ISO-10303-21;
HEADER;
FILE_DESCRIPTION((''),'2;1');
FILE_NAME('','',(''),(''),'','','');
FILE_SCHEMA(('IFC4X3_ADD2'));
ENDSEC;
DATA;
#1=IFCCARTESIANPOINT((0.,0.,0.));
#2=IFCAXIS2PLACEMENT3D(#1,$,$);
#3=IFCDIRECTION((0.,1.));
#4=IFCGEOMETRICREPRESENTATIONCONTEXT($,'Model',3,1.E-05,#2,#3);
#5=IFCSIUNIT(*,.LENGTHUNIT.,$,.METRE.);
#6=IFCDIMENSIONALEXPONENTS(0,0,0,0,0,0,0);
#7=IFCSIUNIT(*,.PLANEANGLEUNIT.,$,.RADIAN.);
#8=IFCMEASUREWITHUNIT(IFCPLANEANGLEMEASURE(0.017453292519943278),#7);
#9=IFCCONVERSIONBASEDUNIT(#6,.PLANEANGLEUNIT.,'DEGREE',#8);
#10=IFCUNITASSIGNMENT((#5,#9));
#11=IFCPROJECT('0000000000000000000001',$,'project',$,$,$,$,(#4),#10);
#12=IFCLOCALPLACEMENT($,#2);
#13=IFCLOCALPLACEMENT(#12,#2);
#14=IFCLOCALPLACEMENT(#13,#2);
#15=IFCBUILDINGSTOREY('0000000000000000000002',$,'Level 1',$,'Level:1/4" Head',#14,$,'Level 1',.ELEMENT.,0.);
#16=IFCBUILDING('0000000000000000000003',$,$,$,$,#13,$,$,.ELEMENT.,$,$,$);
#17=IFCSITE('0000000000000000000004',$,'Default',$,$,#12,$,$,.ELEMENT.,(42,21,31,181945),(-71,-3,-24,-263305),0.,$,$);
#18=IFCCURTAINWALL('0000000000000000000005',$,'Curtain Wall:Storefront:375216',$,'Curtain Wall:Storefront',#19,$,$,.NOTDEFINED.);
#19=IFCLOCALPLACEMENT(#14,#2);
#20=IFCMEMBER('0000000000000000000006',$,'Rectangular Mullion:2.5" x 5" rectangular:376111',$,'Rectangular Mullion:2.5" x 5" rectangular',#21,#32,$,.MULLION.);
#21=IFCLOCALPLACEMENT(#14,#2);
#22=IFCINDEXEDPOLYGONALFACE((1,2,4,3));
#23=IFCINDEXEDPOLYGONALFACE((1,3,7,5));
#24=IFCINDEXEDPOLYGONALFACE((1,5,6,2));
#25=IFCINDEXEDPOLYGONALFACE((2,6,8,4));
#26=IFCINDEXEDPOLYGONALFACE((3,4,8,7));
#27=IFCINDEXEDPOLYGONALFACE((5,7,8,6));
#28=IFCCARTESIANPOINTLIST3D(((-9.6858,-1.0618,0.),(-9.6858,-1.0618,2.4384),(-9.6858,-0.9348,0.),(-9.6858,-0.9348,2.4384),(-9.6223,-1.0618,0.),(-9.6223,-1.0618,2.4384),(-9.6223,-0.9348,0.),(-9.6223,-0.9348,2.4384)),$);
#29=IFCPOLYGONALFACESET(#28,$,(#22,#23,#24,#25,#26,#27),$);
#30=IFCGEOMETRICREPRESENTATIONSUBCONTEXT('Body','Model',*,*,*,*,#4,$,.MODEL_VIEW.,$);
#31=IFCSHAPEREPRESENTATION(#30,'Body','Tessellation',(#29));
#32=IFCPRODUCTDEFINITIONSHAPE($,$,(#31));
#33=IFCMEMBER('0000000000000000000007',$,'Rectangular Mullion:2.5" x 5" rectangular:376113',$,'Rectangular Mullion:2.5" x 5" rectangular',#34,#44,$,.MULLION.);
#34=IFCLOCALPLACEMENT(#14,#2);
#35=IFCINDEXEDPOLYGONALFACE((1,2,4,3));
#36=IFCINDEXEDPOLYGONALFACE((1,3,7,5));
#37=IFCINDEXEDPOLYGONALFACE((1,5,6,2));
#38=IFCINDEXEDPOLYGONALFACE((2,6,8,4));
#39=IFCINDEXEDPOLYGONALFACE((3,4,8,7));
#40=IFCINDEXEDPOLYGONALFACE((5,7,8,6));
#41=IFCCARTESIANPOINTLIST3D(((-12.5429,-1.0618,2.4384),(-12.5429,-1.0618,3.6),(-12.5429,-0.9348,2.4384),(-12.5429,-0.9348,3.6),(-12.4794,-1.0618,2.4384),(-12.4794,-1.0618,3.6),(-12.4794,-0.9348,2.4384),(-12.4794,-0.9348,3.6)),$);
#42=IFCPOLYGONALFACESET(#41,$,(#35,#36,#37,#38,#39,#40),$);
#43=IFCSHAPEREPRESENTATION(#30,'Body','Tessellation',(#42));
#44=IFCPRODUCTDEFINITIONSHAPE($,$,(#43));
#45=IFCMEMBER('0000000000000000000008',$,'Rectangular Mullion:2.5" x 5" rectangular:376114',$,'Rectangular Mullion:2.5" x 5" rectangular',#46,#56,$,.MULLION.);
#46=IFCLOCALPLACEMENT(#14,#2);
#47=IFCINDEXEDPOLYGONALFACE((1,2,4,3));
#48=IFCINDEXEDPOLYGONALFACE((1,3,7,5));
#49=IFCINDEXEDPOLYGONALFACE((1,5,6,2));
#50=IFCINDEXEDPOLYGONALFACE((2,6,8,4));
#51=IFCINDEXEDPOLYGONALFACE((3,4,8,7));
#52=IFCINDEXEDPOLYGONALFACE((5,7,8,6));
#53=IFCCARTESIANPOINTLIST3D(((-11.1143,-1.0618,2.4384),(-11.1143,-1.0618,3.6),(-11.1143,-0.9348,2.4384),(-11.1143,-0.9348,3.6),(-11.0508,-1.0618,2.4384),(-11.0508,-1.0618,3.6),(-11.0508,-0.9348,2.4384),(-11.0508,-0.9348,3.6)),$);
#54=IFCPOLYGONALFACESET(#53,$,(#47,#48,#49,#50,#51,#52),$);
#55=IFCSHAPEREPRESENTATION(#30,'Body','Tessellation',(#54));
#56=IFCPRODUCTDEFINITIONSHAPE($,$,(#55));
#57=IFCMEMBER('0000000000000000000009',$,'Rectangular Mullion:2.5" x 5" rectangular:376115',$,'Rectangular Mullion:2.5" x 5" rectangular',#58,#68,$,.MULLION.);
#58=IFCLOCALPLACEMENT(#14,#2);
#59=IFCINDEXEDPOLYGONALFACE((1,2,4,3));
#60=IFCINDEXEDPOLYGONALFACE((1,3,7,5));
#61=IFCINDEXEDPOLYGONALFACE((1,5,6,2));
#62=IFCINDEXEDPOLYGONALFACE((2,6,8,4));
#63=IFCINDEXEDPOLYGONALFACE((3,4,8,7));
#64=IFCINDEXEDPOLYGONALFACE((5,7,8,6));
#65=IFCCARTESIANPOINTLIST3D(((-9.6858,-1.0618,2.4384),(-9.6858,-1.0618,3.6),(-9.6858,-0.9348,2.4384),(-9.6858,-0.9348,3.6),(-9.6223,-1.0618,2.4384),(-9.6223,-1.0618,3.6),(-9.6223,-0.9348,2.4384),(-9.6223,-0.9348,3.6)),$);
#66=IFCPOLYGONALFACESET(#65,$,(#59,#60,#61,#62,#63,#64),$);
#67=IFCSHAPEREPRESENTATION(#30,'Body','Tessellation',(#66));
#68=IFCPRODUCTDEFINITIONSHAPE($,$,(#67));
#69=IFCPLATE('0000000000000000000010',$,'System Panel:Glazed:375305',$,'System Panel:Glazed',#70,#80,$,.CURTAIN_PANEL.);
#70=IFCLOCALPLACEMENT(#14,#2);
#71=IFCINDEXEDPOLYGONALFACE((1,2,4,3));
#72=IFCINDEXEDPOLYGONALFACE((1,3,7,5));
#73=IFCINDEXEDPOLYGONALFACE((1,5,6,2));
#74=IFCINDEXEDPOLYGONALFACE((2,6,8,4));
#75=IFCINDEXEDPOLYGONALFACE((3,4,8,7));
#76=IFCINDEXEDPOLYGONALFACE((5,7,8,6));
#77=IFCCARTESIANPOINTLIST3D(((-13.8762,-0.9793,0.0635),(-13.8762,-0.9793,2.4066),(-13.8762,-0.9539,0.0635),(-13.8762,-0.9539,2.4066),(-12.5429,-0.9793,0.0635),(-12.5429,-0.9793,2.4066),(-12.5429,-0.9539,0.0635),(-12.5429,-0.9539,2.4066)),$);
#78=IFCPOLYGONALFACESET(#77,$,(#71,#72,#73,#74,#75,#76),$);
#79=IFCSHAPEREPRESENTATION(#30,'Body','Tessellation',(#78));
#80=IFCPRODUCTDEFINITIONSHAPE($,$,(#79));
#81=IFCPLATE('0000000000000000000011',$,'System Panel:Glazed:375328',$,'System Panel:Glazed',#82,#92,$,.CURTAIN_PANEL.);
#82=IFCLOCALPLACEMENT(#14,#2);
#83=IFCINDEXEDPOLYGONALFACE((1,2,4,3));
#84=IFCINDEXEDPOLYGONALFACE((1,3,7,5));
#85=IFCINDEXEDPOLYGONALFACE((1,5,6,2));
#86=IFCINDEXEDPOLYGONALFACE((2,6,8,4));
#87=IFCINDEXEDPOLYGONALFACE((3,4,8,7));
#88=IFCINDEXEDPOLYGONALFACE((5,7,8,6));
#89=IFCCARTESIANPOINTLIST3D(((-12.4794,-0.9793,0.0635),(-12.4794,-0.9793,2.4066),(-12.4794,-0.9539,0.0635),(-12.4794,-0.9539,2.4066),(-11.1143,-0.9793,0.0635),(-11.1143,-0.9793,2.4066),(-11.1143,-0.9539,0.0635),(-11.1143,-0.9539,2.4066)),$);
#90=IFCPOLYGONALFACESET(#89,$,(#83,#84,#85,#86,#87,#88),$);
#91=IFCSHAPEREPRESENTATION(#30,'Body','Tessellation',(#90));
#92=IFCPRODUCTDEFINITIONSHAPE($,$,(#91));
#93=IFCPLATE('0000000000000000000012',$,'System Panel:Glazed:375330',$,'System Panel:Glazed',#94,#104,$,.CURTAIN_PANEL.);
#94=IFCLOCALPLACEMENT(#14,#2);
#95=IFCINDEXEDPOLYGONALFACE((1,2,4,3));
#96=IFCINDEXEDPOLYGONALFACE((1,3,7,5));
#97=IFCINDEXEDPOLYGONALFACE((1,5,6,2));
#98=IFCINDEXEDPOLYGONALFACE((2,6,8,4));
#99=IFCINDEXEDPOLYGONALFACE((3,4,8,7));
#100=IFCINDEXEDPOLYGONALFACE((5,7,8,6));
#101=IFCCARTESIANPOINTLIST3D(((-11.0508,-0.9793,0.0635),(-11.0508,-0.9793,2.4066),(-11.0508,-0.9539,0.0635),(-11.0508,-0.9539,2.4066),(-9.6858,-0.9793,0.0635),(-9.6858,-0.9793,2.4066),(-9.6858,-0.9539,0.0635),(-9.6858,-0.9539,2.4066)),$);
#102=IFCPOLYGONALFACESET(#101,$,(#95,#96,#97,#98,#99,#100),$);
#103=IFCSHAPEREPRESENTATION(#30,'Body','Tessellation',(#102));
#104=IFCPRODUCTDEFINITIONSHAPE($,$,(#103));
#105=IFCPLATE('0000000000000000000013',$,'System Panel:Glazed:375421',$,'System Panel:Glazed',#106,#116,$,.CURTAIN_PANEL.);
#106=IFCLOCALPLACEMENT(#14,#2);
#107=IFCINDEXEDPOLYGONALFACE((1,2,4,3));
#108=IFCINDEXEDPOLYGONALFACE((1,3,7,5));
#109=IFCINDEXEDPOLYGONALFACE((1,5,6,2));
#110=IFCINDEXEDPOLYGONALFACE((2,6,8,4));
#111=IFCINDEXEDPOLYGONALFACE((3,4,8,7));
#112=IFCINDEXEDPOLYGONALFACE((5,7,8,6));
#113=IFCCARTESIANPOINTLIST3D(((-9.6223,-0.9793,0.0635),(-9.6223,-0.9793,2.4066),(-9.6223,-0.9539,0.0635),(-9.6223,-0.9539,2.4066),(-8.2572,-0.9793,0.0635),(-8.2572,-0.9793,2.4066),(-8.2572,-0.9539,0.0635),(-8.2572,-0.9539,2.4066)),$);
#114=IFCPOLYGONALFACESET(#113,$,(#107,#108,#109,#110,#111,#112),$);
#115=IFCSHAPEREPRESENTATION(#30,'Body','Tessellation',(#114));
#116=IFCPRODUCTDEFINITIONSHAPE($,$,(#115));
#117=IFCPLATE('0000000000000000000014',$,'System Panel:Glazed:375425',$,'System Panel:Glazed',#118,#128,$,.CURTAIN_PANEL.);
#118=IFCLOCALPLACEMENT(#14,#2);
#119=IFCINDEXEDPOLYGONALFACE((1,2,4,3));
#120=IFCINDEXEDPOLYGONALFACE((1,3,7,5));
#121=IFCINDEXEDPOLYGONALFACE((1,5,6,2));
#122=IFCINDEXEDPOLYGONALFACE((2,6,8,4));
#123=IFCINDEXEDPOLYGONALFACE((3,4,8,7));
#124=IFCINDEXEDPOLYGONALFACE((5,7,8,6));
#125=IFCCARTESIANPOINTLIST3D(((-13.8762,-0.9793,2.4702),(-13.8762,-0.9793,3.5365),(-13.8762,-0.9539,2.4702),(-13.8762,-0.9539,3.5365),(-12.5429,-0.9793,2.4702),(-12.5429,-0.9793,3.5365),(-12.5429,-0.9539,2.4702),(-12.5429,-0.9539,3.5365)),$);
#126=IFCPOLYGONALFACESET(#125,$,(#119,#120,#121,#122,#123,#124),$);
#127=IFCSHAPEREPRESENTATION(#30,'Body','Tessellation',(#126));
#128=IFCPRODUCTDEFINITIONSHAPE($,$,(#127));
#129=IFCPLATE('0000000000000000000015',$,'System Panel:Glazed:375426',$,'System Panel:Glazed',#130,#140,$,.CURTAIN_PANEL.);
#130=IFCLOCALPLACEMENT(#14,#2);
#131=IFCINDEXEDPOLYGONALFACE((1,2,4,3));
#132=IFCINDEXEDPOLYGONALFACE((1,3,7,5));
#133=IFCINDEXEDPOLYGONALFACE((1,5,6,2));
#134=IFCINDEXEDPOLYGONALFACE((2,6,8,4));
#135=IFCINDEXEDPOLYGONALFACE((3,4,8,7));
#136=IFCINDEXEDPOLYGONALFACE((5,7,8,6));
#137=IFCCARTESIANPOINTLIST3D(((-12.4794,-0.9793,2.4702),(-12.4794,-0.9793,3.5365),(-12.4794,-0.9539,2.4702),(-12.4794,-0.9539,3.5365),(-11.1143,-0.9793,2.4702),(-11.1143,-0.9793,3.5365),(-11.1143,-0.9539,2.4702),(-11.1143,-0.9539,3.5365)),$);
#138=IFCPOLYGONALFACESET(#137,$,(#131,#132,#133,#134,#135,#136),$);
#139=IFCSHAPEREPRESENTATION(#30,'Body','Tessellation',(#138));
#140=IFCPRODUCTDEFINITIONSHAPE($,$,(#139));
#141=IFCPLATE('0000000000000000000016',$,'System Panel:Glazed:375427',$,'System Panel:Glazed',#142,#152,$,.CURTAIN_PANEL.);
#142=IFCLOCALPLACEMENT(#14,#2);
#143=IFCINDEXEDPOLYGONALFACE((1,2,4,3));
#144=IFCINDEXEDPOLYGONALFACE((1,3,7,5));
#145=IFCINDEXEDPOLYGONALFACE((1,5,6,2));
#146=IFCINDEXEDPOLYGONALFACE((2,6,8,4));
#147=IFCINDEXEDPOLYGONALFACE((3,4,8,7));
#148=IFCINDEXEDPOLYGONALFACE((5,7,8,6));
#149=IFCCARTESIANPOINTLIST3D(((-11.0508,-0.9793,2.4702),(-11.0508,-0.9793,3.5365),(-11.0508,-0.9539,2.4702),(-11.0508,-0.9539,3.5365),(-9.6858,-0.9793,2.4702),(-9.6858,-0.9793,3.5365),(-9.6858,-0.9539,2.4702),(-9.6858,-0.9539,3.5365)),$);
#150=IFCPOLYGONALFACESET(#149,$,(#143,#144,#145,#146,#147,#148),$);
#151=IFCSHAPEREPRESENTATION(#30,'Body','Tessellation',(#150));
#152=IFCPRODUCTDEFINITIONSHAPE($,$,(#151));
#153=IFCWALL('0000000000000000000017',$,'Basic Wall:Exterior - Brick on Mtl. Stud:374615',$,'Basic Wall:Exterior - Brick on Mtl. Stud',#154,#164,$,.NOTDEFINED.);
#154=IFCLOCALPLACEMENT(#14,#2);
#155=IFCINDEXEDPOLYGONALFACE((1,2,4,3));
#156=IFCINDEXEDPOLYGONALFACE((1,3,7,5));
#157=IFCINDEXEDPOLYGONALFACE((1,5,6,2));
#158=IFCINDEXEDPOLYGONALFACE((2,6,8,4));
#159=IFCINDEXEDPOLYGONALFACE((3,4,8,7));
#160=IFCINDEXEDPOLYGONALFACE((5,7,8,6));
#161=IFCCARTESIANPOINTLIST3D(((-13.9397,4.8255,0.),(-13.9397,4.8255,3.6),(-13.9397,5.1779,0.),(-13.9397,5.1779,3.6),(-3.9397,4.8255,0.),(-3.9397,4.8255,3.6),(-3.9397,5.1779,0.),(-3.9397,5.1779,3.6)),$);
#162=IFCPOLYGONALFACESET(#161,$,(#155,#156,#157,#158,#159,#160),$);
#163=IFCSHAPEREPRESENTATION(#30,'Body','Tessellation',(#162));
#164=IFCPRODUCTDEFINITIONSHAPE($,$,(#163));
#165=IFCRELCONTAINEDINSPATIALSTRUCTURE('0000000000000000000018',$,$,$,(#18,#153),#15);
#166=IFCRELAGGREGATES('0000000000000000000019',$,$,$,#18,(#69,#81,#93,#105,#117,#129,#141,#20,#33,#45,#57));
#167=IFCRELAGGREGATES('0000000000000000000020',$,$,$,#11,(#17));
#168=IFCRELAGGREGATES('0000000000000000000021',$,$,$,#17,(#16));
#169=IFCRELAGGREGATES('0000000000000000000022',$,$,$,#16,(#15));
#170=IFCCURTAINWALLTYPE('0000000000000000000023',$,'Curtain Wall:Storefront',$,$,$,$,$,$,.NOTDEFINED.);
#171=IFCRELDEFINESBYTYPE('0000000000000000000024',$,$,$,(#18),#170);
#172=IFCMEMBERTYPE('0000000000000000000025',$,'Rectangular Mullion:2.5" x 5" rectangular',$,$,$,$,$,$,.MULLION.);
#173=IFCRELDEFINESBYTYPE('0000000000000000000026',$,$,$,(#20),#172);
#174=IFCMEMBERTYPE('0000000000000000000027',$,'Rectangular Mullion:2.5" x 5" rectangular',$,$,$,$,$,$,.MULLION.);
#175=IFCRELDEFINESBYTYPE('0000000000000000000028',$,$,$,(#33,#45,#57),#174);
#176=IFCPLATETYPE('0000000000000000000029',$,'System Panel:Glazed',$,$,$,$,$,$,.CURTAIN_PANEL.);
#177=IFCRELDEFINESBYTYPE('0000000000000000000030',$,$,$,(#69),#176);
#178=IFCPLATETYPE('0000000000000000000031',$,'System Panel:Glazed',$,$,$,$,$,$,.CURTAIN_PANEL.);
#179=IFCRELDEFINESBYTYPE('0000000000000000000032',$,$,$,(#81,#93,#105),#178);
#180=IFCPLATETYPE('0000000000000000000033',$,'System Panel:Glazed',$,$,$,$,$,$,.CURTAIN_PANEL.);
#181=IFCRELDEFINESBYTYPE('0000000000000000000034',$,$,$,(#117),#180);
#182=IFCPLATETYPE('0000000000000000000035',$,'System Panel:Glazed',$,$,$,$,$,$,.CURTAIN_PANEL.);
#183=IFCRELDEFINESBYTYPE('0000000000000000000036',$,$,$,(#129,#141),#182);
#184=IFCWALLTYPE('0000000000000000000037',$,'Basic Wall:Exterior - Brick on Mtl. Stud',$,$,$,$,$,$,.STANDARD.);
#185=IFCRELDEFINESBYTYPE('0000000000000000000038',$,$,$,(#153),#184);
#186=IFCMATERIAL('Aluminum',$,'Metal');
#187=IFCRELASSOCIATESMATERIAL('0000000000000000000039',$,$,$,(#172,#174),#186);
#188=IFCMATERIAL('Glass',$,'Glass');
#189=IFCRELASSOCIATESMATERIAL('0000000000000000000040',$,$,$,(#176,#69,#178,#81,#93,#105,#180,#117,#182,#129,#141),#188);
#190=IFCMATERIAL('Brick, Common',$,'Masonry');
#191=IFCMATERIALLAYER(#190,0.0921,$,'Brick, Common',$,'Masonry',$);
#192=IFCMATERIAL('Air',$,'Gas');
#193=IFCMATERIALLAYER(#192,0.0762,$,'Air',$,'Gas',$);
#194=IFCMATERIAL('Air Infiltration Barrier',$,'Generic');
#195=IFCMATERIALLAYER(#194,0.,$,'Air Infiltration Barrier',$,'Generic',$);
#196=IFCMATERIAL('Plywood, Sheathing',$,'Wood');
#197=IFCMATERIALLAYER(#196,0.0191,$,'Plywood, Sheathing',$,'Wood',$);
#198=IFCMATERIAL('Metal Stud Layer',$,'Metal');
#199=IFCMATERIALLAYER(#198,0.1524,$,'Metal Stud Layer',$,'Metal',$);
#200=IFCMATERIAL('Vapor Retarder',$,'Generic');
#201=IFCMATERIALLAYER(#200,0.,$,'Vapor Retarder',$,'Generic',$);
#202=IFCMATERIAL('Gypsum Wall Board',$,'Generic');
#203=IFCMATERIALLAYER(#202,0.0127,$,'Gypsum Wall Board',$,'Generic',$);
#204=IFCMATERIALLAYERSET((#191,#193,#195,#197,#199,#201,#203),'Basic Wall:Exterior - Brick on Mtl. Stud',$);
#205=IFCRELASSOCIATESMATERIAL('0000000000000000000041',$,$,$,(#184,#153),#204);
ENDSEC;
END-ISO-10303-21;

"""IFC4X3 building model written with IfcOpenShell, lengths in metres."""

from ifc_helpers import new_model, entity, si_unit, converted_unit, direction, frame, frame_2d, origin, origin_2d_with_axis, place, context, subcontext, project, spatial, rectangle, extrude, source, transform, mapped, material, layer, layer_set, material_profile, profile_set, type_object, type_shapes, element, aggregate, save


model = new_model("IFC4X3")

# Units and contexts
model_context = context("Model", 3, precision=1e-05, world=origin(), true_north=direction((0.0, 1.0)))
body_context = subcontext(model_context, "Body", "Model", "MODEL_VIEW")
ifc_project = project(units=[si_unit("LENGTHUNIT", "METRE"), converted_unit("PLANEANGLEUNIT", "DEGREE", entity("IfcPlaneAngleMeasure", 0.017453292519943278), si_unit("PLANEANGLEUNIT", "RADIAN"), dimensions=[0, 0, 0, 0, 0, 0, 0])], contexts=[model_context])

# Site, building, storey
site_placement = place(None, origin())
site = spatial("IfcSite", under=ifc_project, at=site_placement, Name="Default", CompositionType="ELEMENT", RefLatitude=(42, 21, 31, 181945), RefLongitude=(-71, -3, -24, -263305), RefElevation=0.0)
building_placement = place(site_placement, origin())
building = spatial("IfcBuilding", under=site, at=building_placement, CompositionType="ELEMENT")
storey_placement = place(building_placement, origin())
storey = spatial("IfcBuildingStorey", under=building, at=storey_placement, Name="Level 1", ObjectType="Level:1/4\" Head", LongName="Level 1", CompositionType="ELEMENT", Elevation=0.0)

# Curtain wall, members, plates
curtain_wall_type = type_object("IfcCurtainWallType", Name="Curtain Wall:Storefront", PredefinedType="NOTDEFINED")
curtain_wall_placement = place(storey_placement, origin())
curtain_wall = element("IfcCurtainWall", 1, at=curtain_wall_placement, inside=storey, type_object=curtain_wall_type, Name="Curtain Wall:Storefront:375216", ObjectType="Curtain Wall:Storefront", PredefinedType="NOTDEFINED")
ifc_material_1 = material(Name="Aluminum", Category="Metal")
ifc_material_profile = material_profile(ifc_material_1, rectangle(XDim=0.0635, YDim=0.127, at=frame_2d((0.0, 0.0), x_axis=(1.0, 0.0))), Name="2.5\" x 5\" rectangular")
ifc_profile_set = profile_set([ifc_material_profile], Name="2.5\" x 5\" rectangular")
member_type_1 = type_object("IfcMemberType", Name="Rectangular Mullion:2.5\" x 5\" rectangular", PredefinedType="MULLION", material=ifc_profile_set)
shared_shape_1 = source(origin(), body_context, "Body", "SweptSolid", [
    extrude(rectangle(XDim=0.0635, YDim=0.127, at=origin_2d_with_axis()), frame((0.0, 0.0, -2.4384), z_axis=(0.0, 0.0, 1.0), x_axis=(-1.0, 0.0, 0.0)), (0.0, 0.0, 1.0), 2.4384),
])
type_shapes(member_type_1, [shared_shape_1])
member_1_placement = place(curtain_wall_placement, frame((-9.654, -0.9983, 0.0), z_axis=(0.0, 0.0, -1.0), x_axis=(1.0, 0.0, 0.0)))
member_1 = element("IfcMember", 2, at=member_1_placement, type_object=member_type_1, Name="Rectangular Mullion:2.5\" x 5\" rectangular:376111", ObjectType="Rectangular Mullion:2.5\" x 5\" rectangular", PredefinedType="MULLION", context=body_context, shape_type="MappedRepresentation", body=[
    mapped(shared_shape_1, transform((0.0, 0.0, 0.0), scale=1.0)),
])
member_type_2 = type_object("IfcMemberType", Name="Rectangular Mullion:2.5\" x 5\" rectangular", PredefinedType="MULLION", material=ifc_profile_set)
shared_shape_2 = source(origin(), body_context, "Body", "SweptSolid", [
    extrude(rectangle(XDim=0.0635, YDim=0.127, at=origin_2d_with_axis()), frame((0.0, 0.0, -1.1616), z_axis=(0.0, 0.0, 1.0), x_axis=(-1.0, 0.0, 0.0)), (0.0, 0.0, 1.0), 1.1616),
])
type_shapes(member_type_2, [shared_shape_2])
member_2_placement = place(curtain_wall_placement, frame((-12.5112, -0.9983, 2.4384), z_axis=(0.0, 0.0, -1.0), x_axis=(1.0, 0.0, 0.0)))
member_2 = element("IfcMember", 3, at=member_2_placement, type_object=member_type_2, Name="Rectangular Mullion:2.5\" x 5\" rectangular:376113", ObjectType="Rectangular Mullion:2.5\" x 5\" rectangular", PredefinedType="MULLION", context=body_context, shape_type="MappedRepresentation", body=[
    mapped(shared_shape_2, transform((0.0, 0.0, 0.0), scale=1.0)),
])
member_3_placement = place(curtain_wall_placement, frame((-11.0826, -0.9983, 2.4384), z_axis=(0.0, 0.0, -1.0), x_axis=(1.0, 0.0, 0.0)))
member_3 = element("IfcMember", 4, at=member_3_placement, type_object=member_type_2, Name="Rectangular Mullion:2.5\" x 5\" rectangular:376114", ObjectType="Rectangular Mullion:2.5\" x 5\" rectangular", PredefinedType="MULLION", context=body_context, shape_type="MappedRepresentation", body=[
    mapped(shared_shape_2, transform((0.0, 0.0, 0.0), scale=1.0)),
])
member_4_placement = place(curtain_wall_placement, frame((-9.654, -0.9983, 2.4384), z_axis=(0.0, 0.0, -1.0), x_axis=(1.0, 0.0, 0.0)))
member_4 = element("IfcMember", 5, at=member_4_placement, type_object=member_type_2, Name="Rectangular Mullion:2.5\" x 5\" rectangular:376115", ObjectType="Rectangular Mullion:2.5\" x 5\" rectangular", PredefinedType="MULLION", context=body_context, shape_type="MappedRepresentation", body=[
    mapped(shared_shape_2, transform((0.0, 0.0, 0.0), scale=1.0)),
])
ifc_material_2 = material(Name="Glass", Category="Glass")
plate_type_1 = type_object("IfcPlateType", Name="System Panel:Glazed", PredefinedType="CURTAIN_PANEL", material=ifc_material_2)
shared_shape_3 = source(origin(), body_context, "Body", "SweptSolid", [
    extrude(rectangle(XDim=0.0254, YDim=1.3333, at=frame_2d((0.0, 0.0), x_axis=(1.0, 0.0))), frame((0.6667, 0.0127, 0.0), z_axis=(0.0, 0.0, 1.0), x_axis=(0.0, 1.0, 0.0)), (0.0, 0.0, 1.0), 2.3432),
])
type_shapes(plate_type_1, [shared_shape_3])
plate_1_placement = place(curtain_wall_placement, frame((-13.8762, -0.9793, 0.0635)))
plate_1 = element("IfcPlate", 6, at=plate_1_placement, type_object=plate_type_1, material=ifc_material_2, Name="System Panel:Glazed:375305", ObjectType="System Panel:Glazed", PredefinedType="CURTAIN_PANEL", context=body_context, shape_type="MappedRepresentation", body=[
    mapped(shared_shape_3, transform((0.0, 0.0, 0.0), scale=1.0)),
])
plate_type_2 = type_object("IfcPlateType", Name="System Panel:Glazed", PredefinedType="CURTAIN_PANEL", material=ifc_material_2)
shared_shape_4 = source(origin(), body_context, "Body", "SweptSolid", [
    extrude(rectangle(XDim=0.0254, YDim=1.3651, at=frame_2d((0.0, 0.0), x_axis=(1.0, 0.0))), frame((0.6825, 0.0127, 0.0), z_axis=(0.0, 0.0, 1.0), x_axis=(0.0, 1.0, 0.0)), (0.0, 0.0, 1.0), 2.3432),
])
type_shapes(plate_type_2, [shared_shape_4])
plate_2_placement = place(curtain_wall_placement, frame((-12.4794, -0.9793, 0.0635)))
plate_2 = element("IfcPlate", 7, at=plate_2_placement, type_object=plate_type_2, material=ifc_material_2, Name="System Panel:Glazed:375328", ObjectType="System Panel:Glazed", PredefinedType="CURTAIN_PANEL", context=body_context, shape_type="MappedRepresentation", body=[
    mapped(shared_shape_4, transform((0.0, 0.0, 0.0), scale=1.0)),
])
plate_3_placement = place(curtain_wall_placement, frame((-11.0508, -0.9793, 0.0635)))
plate_3 = element("IfcPlate", 8, at=plate_3_placement, type_object=plate_type_2, material=ifc_material_2, Name="System Panel:Glazed:375330", ObjectType="System Panel:Glazed", PredefinedType="CURTAIN_PANEL", context=body_context, shape_type="MappedRepresentation", body=[
    mapped(shared_shape_4, transform((0.0, 0.0, 0.0), scale=1.0)),
])
plate_4_placement = place(curtain_wall_placement, frame((-9.6223, -0.9793, 0.0635)))
plate_4 = element("IfcPlate", 9, at=plate_4_placement, type_object=plate_type_2, material=ifc_material_2, Name="System Panel:Glazed:375421", ObjectType="System Panel:Glazed", PredefinedType="CURTAIN_PANEL", context=body_context, shape_type="MappedRepresentation", body=[
    mapped(shared_shape_4, transform((0.0, 0.0, 0.0), scale=1.0)),
])
plate_type_3 = type_object("IfcPlateType", Name="System Panel:Glazed", PredefinedType="CURTAIN_PANEL", material=ifc_material_2)
shared_shape_5 = source(origin(), body_context, "Body", "SweptSolid", [
    extrude(rectangle(XDim=0.0254, YDim=1.3333, at=frame_2d((0.0, 0.0), x_axis=(1.0, 0.0))), frame((0.6667, 0.0127, 0.0), z_axis=(0.0, 0.0, 1.0), x_axis=(0.0, 1.0, 0.0)), (0.0, 0.0, 1.0), 1.0663),
])
type_shapes(plate_type_3, [shared_shape_5])
plate_5_placement = place(curtain_wall_placement, frame((-13.8762, -0.9793, 2.4701)))
plate_5 = element("IfcPlate", 10, at=plate_5_placement, type_object=plate_type_3, material=ifc_material_2, Name="System Panel:Glazed:375425", ObjectType="System Panel:Glazed", PredefinedType="CURTAIN_PANEL", context=body_context, shape_type="MappedRepresentation", body=[
    mapped(shared_shape_5, transform((0.0, 0.0, 0.0), scale=1.0)),
])
plate_type_4 = type_object("IfcPlateType", Name="System Panel:Glazed", PredefinedType="CURTAIN_PANEL", material=ifc_material_2)
shared_shape_6 = source(origin(), body_context, "Body", "SweptSolid", [
    extrude(rectangle(XDim=0.0254, YDim=1.3651, at=frame_2d((0.0, 0.0), x_axis=(1.0, 0.0))), frame((0.6825, 0.0127, 0.0), z_axis=(0.0, 0.0, 1.0), x_axis=(0.0, 1.0, 0.0)), (0.0, 0.0, 1.0), 1.0663),
])
type_shapes(plate_type_4, [shared_shape_6])
plate_6_placement = place(curtain_wall_placement, frame((-12.4794, -0.9793, 2.4701)))
plate_6 = element("IfcPlate", 11, at=plate_6_placement, type_object=plate_type_4, material=ifc_material_2, Name="System Panel:Glazed:375426", ObjectType="System Panel:Glazed", PredefinedType="CURTAIN_PANEL", context=body_context, shape_type="MappedRepresentation", body=[
    mapped(shared_shape_6, transform((0.0, 0.0, 0.0), scale=1.0)),
])
plate_7_placement = place(curtain_wall_placement, frame((-11.0508, -0.9793, 2.4701)))
plate_7 = element("IfcPlate", 12, at=plate_7_placement, type_object=plate_type_4, material=ifc_material_2, Name="System Panel:Glazed:375427", ObjectType="System Panel:Glazed", PredefinedType="CURTAIN_PANEL", context=body_context, shape_type="MappedRepresentation", body=[
    mapped(shared_shape_6, transform((0.0, 0.0, 0.0), scale=1.0)),
])
aggregate(curtain_wall, [plate_1, plate_2, plate_3, plate_4, plate_5, plate_6, plate_7, member_1, member_2, member_3, member_4])

# Wall
ifc_material_3 = material(Name="Brick, Common", Category="Masonry")
ifc_layer_1 = layer(ifc_material_3, 0.0921, Name="Brick, Common", Category="Masonry")
ifc_material_4 = material(Name="Air", Category="Gas")
ifc_layer_2 = layer(ifc_material_4, 0.0762, Name="Air", Category="Gas")
ifc_material_5 = material(Name="Air Infiltration Barrier", Category="Generic")
ifc_layer_3 = layer(ifc_material_5, 0.0, Name="Air Infiltration Barrier", Category="Generic")
ifc_material_6 = material(Name="Plywood, Sheathing", Category="Wood")
ifc_layer_4 = layer(ifc_material_6, 0.0191, Name="Plywood, Sheathing", Category="Wood")
ifc_material_7 = material(Name="Metal Stud Layer", Category="Metal")
ifc_layer_5 = layer(ifc_material_7, 0.1524, Name="Metal Stud Layer", Category="Metal")
ifc_material_8 = material(Name="Vapor Retarder", Category="Generic")
ifc_layer_6 = layer(ifc_material_8, 0.0, Name="Vapor Retarder", Category="Generic")
ifc_material_9 = material(Name="Gypsum Wall Board", Category="Generic")
ifc_layer_7 = layer(ifc_material_9, 0.0127, Name="Gypsum Wall Board", Category="Generic")
ifc_layer_set_1 = layer_set([ifc_layer_1, ifc_layer_2, ifc_layer_3, ifc_layer_4, ifc_layer_5, ifc_layer_6, ifc_layer_7], Name="Basic Wall:Exterior - Brick on Mtl. Stud")
wall_type_1 = type_object("IfcWallType", Name="Basic Wall:Exterior - Brick on Mtl. Stud", PredefinedType="STANDARD", material=ifc_layer_set_1)
wall_1_placement = place(storey_placement, frame((-13.9397, 5.0017, 0.0)))
element("IfcWall", 13, at=wall_1_placement, inside=storey, type_object=wall_type_1, material=ifc_layer_set_1, Name="Basic Wall:Exterior - Brick on Mtl. Stud:374615", ObjectType="Basic Wall:Exterior - Brick on Mtl. Stud", PredefinedType="NOTDEFINED", context=body_context, shape_type="SweptSolid", body=[
    extrude(rectangle(XDim=10.0, YDim=0.3524, at=frame_2d((5.0, 0.0), x_axis=(-1.0, 0.0))), origin(), (0.0, 0.0, 1.0), 3.6),
])

save(model, "model.ifc")
